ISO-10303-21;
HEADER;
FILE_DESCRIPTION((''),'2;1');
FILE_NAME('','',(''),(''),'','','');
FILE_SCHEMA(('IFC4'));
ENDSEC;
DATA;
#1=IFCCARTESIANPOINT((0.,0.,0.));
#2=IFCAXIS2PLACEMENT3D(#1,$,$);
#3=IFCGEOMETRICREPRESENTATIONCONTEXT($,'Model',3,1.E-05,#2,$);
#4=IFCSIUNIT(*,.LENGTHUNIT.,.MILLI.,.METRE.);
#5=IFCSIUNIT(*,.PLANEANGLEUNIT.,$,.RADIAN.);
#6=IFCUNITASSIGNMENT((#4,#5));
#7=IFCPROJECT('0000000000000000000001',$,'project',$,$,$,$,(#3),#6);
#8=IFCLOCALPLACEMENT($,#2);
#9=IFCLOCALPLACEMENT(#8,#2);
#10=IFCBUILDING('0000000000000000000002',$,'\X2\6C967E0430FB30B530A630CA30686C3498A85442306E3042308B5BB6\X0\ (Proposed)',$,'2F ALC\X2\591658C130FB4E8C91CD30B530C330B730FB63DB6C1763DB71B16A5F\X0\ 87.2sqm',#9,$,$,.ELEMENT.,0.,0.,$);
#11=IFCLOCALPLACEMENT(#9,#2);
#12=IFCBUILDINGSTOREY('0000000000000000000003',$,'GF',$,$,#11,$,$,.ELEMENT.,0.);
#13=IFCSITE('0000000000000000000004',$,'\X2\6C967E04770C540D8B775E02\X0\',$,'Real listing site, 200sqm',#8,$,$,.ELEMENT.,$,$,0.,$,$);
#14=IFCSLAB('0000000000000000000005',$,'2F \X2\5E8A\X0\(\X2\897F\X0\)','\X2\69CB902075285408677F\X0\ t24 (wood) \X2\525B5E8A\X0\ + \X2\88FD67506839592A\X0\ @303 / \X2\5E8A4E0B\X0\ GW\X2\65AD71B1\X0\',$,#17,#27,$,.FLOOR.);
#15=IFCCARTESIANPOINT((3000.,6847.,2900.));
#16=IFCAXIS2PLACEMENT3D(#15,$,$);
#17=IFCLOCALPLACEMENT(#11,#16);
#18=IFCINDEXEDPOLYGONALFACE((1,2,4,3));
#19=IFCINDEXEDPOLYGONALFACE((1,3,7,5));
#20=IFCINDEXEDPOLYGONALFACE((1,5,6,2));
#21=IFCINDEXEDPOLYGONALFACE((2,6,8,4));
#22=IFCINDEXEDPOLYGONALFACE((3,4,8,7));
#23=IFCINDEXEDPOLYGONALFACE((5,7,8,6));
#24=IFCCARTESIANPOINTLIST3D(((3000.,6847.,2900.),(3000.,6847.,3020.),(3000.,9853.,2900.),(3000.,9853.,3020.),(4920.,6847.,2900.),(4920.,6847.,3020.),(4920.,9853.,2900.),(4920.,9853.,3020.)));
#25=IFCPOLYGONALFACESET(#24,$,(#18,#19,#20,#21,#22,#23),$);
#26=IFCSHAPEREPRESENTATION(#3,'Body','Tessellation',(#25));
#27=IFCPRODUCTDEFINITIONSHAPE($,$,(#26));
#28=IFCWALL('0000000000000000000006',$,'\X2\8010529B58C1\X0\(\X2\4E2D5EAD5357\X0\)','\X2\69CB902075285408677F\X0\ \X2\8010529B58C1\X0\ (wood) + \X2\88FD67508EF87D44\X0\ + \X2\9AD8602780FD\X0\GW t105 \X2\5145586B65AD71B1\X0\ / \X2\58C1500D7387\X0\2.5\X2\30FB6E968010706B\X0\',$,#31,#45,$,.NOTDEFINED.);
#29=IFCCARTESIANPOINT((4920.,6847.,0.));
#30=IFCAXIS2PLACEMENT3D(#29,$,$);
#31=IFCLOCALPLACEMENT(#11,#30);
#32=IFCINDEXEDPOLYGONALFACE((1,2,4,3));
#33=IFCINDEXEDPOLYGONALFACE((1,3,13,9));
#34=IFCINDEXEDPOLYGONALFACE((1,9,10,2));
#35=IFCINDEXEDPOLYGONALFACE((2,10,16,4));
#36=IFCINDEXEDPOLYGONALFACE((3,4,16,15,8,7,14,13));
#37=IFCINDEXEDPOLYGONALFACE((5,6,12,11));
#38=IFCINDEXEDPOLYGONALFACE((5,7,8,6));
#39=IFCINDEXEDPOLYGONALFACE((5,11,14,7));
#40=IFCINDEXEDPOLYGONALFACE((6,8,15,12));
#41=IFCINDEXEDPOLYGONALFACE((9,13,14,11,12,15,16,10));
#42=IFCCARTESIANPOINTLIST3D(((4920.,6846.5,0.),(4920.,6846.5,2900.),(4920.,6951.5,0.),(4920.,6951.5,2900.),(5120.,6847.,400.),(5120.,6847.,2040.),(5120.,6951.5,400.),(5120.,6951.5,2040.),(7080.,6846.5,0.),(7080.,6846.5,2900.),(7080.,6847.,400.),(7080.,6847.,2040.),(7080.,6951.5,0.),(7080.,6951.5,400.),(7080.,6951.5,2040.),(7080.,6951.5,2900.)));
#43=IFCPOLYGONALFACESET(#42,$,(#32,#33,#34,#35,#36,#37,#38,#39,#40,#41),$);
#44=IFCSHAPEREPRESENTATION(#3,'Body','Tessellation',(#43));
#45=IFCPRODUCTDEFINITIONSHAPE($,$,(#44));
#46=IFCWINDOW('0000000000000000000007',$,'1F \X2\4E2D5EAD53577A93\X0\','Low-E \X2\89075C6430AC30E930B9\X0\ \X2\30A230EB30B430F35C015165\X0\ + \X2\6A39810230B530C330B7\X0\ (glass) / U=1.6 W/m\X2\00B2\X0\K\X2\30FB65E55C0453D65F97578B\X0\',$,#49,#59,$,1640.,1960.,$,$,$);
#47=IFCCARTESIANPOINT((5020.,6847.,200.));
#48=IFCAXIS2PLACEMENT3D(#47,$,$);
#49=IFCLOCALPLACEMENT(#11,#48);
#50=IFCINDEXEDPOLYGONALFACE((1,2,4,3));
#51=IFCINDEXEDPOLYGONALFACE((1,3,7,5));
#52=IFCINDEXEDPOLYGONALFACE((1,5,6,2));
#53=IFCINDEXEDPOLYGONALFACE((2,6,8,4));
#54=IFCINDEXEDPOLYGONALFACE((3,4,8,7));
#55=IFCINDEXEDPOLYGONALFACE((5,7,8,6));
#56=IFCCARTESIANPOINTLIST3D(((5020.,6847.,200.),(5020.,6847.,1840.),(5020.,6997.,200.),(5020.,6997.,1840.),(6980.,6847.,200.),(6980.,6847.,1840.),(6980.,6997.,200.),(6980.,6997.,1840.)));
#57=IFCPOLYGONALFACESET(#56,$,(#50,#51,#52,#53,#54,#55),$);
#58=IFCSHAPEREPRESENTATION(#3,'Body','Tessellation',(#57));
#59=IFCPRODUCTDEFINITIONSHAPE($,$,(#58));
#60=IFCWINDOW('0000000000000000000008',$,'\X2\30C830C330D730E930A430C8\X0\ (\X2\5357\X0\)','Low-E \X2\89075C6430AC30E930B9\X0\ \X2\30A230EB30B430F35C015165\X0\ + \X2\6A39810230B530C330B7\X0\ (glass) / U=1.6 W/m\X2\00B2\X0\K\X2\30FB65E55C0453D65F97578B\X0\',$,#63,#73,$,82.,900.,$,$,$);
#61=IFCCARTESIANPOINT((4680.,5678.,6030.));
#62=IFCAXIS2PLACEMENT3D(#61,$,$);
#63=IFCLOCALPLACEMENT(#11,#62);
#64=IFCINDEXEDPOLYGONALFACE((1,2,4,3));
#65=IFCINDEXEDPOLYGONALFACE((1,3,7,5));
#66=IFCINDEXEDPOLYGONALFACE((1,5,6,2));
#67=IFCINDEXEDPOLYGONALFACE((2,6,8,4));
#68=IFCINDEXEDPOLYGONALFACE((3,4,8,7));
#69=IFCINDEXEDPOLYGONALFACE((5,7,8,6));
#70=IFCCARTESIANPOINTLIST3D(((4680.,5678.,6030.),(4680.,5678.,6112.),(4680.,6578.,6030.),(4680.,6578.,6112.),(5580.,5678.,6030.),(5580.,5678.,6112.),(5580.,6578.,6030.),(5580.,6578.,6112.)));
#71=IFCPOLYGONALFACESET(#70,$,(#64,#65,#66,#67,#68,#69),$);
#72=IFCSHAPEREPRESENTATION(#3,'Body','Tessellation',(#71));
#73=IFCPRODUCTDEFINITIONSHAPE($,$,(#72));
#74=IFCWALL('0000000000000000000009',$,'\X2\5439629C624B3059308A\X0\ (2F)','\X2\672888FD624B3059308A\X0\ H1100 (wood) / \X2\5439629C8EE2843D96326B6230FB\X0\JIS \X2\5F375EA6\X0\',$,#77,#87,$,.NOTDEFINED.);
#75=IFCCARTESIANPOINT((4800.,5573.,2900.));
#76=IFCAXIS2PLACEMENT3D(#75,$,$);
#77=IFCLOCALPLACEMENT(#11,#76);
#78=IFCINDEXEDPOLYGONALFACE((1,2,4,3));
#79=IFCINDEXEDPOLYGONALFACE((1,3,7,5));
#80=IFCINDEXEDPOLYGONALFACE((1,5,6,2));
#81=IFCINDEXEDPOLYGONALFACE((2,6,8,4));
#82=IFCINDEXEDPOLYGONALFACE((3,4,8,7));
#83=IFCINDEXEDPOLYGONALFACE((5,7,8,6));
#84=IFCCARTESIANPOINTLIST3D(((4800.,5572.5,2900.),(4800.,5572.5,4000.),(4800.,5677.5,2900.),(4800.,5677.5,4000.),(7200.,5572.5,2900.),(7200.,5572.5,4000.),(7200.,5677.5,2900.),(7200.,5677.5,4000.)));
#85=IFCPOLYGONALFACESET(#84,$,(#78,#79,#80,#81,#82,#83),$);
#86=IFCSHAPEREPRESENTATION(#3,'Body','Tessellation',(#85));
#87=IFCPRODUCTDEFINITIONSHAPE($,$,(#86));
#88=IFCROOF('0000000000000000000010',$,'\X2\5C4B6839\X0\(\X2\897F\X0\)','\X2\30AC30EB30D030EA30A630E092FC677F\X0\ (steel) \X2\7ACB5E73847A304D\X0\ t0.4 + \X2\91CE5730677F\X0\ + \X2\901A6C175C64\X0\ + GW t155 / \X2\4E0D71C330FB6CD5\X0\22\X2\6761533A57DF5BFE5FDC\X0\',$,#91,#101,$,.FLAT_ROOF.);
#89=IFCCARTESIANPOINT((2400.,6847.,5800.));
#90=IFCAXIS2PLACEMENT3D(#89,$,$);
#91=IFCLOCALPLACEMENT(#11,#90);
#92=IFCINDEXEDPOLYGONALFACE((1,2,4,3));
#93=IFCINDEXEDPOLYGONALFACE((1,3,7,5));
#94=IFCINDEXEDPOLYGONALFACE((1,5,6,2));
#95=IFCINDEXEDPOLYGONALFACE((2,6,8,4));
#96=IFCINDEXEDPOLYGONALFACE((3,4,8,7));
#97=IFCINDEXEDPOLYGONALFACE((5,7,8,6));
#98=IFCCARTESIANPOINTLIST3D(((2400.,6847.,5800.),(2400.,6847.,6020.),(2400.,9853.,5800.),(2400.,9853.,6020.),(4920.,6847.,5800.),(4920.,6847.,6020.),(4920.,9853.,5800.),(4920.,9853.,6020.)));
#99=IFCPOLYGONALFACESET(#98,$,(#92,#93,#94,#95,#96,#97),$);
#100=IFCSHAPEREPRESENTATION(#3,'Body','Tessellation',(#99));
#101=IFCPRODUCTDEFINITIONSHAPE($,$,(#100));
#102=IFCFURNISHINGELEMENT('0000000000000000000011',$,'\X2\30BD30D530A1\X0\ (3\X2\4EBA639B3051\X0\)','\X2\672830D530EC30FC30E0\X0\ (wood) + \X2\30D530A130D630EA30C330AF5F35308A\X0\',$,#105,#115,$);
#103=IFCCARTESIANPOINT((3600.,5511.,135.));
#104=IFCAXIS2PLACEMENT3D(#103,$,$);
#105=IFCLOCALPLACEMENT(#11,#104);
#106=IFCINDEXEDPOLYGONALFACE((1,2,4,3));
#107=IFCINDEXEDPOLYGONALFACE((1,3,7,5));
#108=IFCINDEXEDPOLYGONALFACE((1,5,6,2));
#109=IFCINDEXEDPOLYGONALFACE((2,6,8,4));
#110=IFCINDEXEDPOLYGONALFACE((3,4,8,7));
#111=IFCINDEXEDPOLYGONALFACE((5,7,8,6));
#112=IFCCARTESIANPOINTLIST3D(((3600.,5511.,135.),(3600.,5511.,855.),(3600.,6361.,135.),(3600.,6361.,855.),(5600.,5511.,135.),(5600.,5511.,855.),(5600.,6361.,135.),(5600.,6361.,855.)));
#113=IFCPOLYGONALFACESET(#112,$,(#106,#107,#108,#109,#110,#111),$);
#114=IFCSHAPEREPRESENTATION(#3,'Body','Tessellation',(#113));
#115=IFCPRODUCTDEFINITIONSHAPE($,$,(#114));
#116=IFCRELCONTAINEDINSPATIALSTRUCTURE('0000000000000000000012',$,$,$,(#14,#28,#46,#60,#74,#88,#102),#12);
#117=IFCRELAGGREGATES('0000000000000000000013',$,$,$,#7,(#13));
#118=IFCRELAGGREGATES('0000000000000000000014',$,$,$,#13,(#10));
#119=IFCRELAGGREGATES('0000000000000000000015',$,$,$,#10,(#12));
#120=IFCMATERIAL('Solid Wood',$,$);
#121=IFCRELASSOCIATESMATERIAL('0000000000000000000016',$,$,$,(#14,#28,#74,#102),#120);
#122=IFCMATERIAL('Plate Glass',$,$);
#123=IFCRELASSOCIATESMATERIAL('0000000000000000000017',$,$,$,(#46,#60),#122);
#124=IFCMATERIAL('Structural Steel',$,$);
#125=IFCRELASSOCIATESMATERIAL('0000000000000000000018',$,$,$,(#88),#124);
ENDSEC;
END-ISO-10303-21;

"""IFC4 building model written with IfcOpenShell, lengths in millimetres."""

from ifc_helpers import new_model, si_unit, frame, frame_2d, origin, place, context, project, spatial, rectangle, extrude, material, element, fill, save


model = new_model("IFC4")

# Units and contexts
model_context = context("Model", 3, precision=1e-05, world=origin())
ifc_project = project(units=[si_unit("LENGTHUNIT", "METRE", prefix="MILLI"), si_unit("PLANEANGLEUNIT", "RADIAN")], contexts=[model_context])

# Site, building, storey
site_placement = place(None, origin())
site = spatial("IfcSite", under=ifc_project, at=site_placement, Name="沖縄県名護市", ObjectType="Real listing site, 200sqm", CompositionType="ELEMENT", RefElevation=0.0)
building_placement = place(site_placement, origin())
building = spatial("IfcBuilding", under=site, at=building_placement, Name="沖縄・サウナと水風呂のある家 (Proposed)", ObjectType="2F ALC外壁・二重サッシ・換気換熱機 87.2sqm", CompositionType="ELEMENT", ElevationOfRefHeight=0.0, ElevationOfTerrain=0.0)
storey_placement = place(building_placement, origin())
storey = spatial("IfcBuildingStorey", under=building, at=storey_placement, Name="GF", CompositionType="ELEMENT", Elevation=0.0)

# Shared definitions
ifc_material_1 = material(Name="Solid Wood")

# Slab
slab_1_placement = place(storey_placement, frame((3000.0, 6847.0, 2900.0)))
element("IfcSlab", 1, at=slab_1_placement, inside=storey, material=ifc_material_1, Name="2F 床(西)", Description="構造用合板 t24 (wood) 剛床 + 製材根太 @303 / 床下 GW断熱", PredefinedType="FLOOR", context=model_context, shape_type="SweptSolid", body=[
    extrude(rectangle(XDim=1920.0, YDim=3006.0, at=frame_2d((960.0, 1503.0))), frame((3000.0, 6847.0, 2900.0)), (0.0, 0.0, 1.0), 120.0),
])

# Wall, opening, window
wall_1_placement = place(storey_placement, frame((4920.0, 6847.0, 0.0)))
wall_1 = element("IfcWall", 2, at=wall_1_placement, inside=storey, material=ifc_material_1, Name="耐力壁(中庭南)", Description="構造用合板 耐力壁 (wood) + 製材軸組 + 高性能GW t105 充填断熱 / 壁倍率2.5・準耐火", PredefinedType="NOTDEFINED", context=model_context, shape_type="SweptSolid", body=[
    extrude(rectangle(XDim=2160.0, YDim=105.0, at=frame_2d((1080.0, 52.0))), frame((4920.0, 6847.0, 0.0)), (0.0, 0.0, 1.0), 2900.0),
])
opening_placement = place(storey_placement, frame((5020.0, 6847.0, 200.0)))
opening = element("IfcOpeningElement", 3, at=opening_placement, cuts=wall_1, PredefinedType="NOTDEFINED", context=model_context, shape_type="SweptSolid", body=[
    extrude(rectangle(XDim=1960.0, YDim=150.0, at=frame_2d((980.0, 75.0))), frame((5020.0, 6847.0, 200.0)), (0.0, 0.0, 1.0), 1640.0),
])
ifc_material_2 = material(Name="Plate Glass")
window_1_placement = place(storey_placement, frame((5020.0, 6847.0, 200.0)))
window_1 = element("IfcWindow", 4, at=window_1_placement, inside=storey, material=ifc_material_2, Name="1F 中庭南窓", Description="Low-E 複層ガラス アルゴン封入 + 樹脂サッシ (glass) / U=1.6 W/m²K・日射取得型", OverallHeight=1640.0, OverallWidth=1960.0, context=model_context, shape_type="SweptSolid", body=[
    extrude(rectangle(XDim=1960.0, YDim=150.0, at=frame_2d((980.0, 75.0))), frame((5020.0, 6847.0, 200.0)), (0.0, 0.0, 1.0), 1640.0),
])
fill(opening, window_1)

# Window
window_2_placement = place(storey_placement, frame((4680.0, 5678.0, 6030.0)))
element("IfcWindow", 5, at=window_2_placement, inside=storey, material=ifc_material_2, Name="トップライト (南)", Description="Low-E 複層ガラス アルゴン封入 + 樹脂サッシ (glass) / U=1.6 W/m²K・日射取得型", OverallHeight=82.0, OverallWidth=900.0, context=model_context, shape_type="SweptSolid", body=[
    extrude(rectangle(XDim=900.0, YDim=900.0, at=frame_2d((450.0, 450.0))), frame((4680.0, 5678.0, 6030.0)), (0.0, 0.0, 1.0), 82.0),
])

# Wall
wall_2_placement = place(storey_placement, frame((4800.0, 5573.0, 2900.0)))
element("IfcWall", 6, at=wall_2_placement, inside=storey, material=ifc_material_1, Name="吹抜手すり (2F)", Description="木製手すり H1100 (wood) / 吹抜転落防止・JIS 強度", PredefinedType="NOTDEFINED", context=model_context, shape_type="SweptSolid", body=[
    extrude(rectangle(XDim=2400.0, YDim=105.0, at=frame_2d((1200.0, 52.0))), frame((4800.0, 5573.0, 2900.0)), (0.0, 0.0, 1.0), 1100.0),
])

# Roof
ifc_material_3 = material(Name="Structural Steel")
for number, where, name in (
    (7, (2400.0, 6847.0, 5800.0), "屋根(西)"),
):
    element("IfcRoof", number, at=place(storey_placement, frame(where)), inside=storey, material=ifc_material_3, Name=name, Description="ガルバリウム鋼板 (steel) 立平葺き t0.4 + 野地板 + 通気層 + GW t155 / 不燃・法22条区域対応", PredefinedType="FLAT_ROOF", context=model_context, shape_type="SweptSolid", body=[
        extrude(rectangle(XDim=2520.0, YDim=3006.0, at=frame_2d((1260.0, 1503.0))), frame((2400.0, 6847.0, 5800.0)), (0.0, 0.0, 1.0), 220.0),
    ])

# Furnishing element
furnishing_placement = place(storey_placement, frame((3600.0, 5511.0, 135.0)))
element("IfcFurnishingElement", 8, at=furnishing_placement, inside=storey, material=ifc_material_1, Name="ソファ (3人掛け)", Description="木フレーム (wood) + ファブリック張り", context=model_context, shape_type="SweptSolid", body=[
    extrude(rectangle(XDim=2000.0, YDim=850.0, at=frame_2d((1000.0, 425.0))), frame((3600.0, 5511.0, 135.0)), (0.0, 0.0, 1.0), 720.0),
])

save(model, "model.ifc")
